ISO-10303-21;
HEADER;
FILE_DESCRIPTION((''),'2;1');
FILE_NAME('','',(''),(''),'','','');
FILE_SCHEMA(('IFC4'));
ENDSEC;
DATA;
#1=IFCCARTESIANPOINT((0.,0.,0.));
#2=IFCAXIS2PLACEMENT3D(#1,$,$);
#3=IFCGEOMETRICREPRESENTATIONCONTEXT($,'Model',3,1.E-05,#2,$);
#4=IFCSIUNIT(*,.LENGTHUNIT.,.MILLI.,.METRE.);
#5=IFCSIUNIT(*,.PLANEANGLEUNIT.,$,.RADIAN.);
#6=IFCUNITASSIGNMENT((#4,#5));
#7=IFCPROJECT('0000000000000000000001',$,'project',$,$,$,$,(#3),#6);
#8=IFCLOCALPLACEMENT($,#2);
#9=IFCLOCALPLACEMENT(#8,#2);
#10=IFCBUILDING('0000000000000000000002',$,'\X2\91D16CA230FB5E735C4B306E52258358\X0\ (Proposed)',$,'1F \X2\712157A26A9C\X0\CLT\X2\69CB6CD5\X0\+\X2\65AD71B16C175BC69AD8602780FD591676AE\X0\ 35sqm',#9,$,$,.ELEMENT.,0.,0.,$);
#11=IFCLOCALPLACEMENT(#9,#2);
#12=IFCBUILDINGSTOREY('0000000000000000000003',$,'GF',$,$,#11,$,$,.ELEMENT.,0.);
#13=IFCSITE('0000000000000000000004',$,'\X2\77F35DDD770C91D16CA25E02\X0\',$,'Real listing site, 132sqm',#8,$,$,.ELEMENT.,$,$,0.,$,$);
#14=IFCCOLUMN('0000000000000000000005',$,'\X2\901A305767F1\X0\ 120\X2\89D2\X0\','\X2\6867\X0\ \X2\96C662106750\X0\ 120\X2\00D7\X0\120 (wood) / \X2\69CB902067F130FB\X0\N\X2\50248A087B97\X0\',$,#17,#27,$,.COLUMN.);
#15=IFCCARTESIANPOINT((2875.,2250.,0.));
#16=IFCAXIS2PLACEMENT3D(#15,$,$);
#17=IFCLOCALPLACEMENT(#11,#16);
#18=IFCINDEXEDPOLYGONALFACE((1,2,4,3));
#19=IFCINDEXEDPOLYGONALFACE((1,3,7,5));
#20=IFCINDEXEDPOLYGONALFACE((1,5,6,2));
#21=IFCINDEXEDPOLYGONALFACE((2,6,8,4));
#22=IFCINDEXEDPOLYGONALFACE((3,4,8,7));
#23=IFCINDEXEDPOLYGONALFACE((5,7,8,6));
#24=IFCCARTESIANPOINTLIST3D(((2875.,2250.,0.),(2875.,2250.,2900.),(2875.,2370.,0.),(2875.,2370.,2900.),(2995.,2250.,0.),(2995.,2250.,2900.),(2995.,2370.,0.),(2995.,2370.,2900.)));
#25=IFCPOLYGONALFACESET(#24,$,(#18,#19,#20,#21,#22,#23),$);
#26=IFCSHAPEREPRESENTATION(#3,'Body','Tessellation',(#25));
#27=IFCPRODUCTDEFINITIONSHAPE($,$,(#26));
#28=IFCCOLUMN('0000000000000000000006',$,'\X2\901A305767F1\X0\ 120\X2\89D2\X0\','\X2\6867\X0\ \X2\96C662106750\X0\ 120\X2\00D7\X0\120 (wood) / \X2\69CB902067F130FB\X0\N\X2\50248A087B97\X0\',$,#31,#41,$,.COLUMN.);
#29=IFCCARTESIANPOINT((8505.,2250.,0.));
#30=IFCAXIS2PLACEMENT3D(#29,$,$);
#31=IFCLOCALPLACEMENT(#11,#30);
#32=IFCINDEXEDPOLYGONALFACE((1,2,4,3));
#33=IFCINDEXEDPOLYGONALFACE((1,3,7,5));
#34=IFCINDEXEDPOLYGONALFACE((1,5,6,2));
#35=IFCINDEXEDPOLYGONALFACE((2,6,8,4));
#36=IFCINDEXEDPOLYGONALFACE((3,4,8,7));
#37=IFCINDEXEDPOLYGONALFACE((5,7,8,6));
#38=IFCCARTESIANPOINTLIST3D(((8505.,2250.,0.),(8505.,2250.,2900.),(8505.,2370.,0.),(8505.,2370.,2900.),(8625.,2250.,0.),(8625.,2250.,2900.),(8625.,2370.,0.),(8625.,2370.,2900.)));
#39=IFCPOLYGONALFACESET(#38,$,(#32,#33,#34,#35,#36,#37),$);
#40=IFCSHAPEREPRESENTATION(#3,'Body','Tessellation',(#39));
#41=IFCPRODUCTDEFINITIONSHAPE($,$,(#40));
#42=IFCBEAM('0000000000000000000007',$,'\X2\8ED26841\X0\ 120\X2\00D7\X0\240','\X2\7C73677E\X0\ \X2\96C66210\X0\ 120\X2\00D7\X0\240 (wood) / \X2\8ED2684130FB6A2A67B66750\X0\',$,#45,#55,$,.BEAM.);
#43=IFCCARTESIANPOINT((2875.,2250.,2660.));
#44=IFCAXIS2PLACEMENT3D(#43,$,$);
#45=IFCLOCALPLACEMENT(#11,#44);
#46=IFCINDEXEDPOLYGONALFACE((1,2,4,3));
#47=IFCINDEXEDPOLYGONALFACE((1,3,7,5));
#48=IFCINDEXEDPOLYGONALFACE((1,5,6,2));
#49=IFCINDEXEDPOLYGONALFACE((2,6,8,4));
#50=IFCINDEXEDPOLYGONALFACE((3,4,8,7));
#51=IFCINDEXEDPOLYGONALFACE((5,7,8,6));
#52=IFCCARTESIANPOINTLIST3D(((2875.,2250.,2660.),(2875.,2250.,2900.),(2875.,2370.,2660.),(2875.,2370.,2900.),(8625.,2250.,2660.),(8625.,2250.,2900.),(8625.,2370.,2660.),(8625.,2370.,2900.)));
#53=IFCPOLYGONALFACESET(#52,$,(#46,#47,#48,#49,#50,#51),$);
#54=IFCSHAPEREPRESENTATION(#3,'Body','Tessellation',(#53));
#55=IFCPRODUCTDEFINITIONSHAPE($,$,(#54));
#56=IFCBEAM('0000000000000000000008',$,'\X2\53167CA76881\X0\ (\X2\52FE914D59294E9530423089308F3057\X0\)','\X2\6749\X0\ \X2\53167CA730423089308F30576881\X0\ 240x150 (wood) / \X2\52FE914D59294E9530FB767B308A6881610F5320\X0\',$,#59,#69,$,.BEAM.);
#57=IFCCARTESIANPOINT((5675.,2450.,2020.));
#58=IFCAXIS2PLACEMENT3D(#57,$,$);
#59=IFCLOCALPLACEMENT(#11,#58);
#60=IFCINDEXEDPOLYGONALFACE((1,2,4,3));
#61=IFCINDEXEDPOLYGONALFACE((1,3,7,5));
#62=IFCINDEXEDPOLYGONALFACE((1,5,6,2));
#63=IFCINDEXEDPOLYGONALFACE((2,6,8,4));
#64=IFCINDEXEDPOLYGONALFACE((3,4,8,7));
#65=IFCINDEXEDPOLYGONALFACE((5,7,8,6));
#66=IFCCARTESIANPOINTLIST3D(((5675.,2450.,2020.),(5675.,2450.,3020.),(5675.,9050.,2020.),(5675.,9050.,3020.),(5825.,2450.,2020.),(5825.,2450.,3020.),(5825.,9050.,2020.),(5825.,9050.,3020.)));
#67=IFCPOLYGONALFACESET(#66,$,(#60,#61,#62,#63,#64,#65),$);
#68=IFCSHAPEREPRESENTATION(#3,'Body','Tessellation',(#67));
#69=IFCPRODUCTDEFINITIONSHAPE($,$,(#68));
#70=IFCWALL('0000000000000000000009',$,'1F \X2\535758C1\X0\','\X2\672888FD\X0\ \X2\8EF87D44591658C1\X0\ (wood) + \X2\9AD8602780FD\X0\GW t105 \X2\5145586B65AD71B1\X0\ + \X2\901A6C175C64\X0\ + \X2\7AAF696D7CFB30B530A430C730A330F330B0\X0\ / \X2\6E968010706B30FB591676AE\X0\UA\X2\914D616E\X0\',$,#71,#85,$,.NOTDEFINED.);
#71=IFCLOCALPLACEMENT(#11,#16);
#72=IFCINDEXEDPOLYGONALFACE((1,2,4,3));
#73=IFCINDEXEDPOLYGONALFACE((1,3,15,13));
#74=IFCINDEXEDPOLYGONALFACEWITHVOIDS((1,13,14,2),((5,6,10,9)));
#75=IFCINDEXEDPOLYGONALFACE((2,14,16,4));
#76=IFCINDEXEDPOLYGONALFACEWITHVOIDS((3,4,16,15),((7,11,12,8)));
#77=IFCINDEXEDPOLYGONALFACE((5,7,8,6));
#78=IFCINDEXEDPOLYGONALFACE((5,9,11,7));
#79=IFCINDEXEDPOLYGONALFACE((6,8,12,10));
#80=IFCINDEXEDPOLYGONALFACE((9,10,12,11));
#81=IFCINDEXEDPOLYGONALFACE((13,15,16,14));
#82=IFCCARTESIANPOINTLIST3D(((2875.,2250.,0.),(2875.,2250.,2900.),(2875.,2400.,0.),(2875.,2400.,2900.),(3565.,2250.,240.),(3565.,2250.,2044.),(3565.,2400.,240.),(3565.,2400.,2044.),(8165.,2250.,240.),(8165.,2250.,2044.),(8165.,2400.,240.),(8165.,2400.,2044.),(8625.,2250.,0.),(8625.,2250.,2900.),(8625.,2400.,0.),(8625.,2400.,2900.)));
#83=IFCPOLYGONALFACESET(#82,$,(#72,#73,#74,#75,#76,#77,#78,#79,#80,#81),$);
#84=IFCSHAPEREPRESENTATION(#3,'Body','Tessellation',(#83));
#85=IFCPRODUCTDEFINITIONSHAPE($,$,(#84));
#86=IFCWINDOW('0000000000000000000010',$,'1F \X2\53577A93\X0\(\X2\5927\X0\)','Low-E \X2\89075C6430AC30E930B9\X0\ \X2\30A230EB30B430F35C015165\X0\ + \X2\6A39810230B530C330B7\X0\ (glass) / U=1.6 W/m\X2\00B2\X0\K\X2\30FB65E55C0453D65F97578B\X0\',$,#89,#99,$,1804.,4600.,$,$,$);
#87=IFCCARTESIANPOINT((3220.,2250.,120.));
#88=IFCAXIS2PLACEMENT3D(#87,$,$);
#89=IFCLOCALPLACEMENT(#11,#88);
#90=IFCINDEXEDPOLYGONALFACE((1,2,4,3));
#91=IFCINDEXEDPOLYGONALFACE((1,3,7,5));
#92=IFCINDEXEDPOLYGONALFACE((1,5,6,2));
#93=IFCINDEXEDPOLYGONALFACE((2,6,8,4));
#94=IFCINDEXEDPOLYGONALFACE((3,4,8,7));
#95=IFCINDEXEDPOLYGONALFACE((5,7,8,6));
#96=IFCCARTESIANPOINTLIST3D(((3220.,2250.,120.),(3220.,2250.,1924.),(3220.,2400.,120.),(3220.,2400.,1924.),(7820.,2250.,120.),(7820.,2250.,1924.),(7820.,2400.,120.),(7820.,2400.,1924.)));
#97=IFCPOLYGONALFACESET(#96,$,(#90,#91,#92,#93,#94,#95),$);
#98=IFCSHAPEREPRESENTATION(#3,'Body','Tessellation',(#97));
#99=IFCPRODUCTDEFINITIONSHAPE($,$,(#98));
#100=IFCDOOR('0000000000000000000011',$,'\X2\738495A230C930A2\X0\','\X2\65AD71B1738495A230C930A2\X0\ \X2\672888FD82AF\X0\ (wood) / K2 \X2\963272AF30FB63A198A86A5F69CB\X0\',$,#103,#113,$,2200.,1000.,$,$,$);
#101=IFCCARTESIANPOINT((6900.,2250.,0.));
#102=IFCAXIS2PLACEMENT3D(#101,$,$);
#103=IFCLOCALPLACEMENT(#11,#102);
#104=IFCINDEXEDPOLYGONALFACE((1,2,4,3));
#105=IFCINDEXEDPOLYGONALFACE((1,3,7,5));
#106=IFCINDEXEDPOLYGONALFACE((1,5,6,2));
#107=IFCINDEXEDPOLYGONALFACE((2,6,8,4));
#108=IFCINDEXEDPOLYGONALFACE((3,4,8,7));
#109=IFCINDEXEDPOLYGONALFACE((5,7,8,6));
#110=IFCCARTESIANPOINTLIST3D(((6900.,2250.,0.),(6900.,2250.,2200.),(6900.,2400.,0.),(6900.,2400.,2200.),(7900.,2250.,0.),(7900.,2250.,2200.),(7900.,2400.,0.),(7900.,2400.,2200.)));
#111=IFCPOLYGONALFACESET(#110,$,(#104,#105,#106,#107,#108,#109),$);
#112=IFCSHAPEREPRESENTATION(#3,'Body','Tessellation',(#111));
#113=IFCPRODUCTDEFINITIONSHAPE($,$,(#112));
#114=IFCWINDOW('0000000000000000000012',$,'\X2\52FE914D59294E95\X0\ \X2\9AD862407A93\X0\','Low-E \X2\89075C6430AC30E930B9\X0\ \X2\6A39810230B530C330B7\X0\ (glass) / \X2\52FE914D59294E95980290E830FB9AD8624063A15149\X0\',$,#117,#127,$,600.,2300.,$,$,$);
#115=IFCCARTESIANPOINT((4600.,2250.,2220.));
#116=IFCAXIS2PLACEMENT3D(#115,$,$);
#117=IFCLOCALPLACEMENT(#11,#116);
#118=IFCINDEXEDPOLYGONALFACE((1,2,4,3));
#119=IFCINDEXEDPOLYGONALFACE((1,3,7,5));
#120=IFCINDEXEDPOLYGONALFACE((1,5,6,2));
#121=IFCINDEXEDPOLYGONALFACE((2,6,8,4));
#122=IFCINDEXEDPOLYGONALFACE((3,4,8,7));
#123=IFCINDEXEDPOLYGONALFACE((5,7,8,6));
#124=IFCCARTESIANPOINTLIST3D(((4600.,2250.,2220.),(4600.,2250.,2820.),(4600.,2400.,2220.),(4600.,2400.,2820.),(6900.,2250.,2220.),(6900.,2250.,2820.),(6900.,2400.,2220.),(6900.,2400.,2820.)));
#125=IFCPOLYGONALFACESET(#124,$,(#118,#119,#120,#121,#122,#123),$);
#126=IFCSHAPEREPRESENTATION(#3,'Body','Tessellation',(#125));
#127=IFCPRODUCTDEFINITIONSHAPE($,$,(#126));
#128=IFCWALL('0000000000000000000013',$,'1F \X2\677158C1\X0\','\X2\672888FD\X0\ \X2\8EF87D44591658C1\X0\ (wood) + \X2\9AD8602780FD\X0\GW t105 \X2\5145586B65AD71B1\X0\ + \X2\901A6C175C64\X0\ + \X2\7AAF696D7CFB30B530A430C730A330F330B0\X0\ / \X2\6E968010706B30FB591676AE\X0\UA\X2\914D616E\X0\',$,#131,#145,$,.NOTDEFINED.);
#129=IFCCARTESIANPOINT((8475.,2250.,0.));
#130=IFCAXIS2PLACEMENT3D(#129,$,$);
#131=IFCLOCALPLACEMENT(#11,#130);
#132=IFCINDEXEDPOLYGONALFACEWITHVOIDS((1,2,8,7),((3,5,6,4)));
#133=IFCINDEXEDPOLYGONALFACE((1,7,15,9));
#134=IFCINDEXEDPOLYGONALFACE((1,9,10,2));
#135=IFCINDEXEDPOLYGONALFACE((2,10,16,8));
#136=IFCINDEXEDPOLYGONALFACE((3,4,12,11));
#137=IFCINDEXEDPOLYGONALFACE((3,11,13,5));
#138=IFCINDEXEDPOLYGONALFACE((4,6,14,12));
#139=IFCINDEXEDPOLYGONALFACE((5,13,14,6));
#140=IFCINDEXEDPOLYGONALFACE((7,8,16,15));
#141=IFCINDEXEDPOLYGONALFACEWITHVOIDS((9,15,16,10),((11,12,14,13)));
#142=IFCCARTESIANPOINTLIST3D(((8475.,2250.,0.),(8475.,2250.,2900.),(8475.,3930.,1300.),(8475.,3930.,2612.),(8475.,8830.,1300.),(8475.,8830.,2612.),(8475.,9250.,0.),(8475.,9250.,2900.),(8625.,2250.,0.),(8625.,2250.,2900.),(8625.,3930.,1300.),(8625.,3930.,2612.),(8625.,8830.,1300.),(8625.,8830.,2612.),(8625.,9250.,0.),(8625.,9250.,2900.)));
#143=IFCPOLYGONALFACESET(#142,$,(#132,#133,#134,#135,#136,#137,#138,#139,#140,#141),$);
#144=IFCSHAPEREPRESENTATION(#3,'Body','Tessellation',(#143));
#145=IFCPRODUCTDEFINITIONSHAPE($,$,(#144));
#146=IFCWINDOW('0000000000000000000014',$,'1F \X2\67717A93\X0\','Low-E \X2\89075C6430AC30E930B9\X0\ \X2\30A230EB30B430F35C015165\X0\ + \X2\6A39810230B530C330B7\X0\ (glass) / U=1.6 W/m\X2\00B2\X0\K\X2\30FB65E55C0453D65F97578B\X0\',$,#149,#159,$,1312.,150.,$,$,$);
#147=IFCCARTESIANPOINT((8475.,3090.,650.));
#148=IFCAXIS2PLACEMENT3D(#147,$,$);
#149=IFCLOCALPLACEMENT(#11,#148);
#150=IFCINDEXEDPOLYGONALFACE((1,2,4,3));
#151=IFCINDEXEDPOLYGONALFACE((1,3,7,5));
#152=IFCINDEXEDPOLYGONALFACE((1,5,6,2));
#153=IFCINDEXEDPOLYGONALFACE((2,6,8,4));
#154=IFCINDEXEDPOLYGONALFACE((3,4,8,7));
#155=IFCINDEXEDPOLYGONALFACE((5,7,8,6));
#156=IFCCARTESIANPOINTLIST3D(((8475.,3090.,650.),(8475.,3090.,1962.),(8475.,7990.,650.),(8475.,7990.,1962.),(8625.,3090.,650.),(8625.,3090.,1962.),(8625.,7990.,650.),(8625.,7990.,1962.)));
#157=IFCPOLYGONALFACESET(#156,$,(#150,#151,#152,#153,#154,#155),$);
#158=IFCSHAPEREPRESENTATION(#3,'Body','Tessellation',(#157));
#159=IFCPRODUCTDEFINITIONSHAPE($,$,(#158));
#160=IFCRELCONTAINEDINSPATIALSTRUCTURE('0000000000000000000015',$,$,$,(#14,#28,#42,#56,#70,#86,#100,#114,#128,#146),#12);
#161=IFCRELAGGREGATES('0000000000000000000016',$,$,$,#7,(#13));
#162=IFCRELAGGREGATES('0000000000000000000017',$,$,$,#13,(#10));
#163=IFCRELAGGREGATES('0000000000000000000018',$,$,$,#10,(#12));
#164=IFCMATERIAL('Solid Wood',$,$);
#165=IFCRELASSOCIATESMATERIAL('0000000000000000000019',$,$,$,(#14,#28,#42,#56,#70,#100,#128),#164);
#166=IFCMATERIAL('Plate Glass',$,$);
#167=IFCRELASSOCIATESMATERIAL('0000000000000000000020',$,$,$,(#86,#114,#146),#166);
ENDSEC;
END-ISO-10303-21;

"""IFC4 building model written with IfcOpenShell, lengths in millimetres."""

from ifc_helpers import new_model, si_unit, frame, frame_2d, origin, place, context, project, spatial, rectangle, extrude, material, element, fill, save


model = new_model("IFC4")

# Units and contexts
model_context = context("Model", 3, precision=1e-05, world=origin())
ifc_project = project(units=[si_unit("LENGTHUNIT", "METRE", prefix="MILLI"), si_unit("PLANEANGLEUNIT", "RADIAN")], contexts=[model_context])

# Site, building, storey
site_placement = place(None, origin())
site = spatial("IfcSite", under=ifc_project, at=site_placement, Name="石川県金沢市", ObjectType="Real listing site, 132sqm", CompositionType="ELEMENT", RefElevation=0.0)
building_placement = place(site_placement, origin())
building = spatial("IfcBuilding", under=site, at=building_placement, Name="金沢・平屋の別荘 (Proposed)", ObjectType="1F 無垢檜CLT構法+断熱気密高性能外皮 35sqm", CompositionType="ELEMENT", ElevationOfRefHeight=0.0, ElevationOfTerrain=0.0)
storey_placement = place(building_placement, origin())
storey = spatial("IfcBuildingStorey", under=building, at=storey_placement, Name="GF", CompositionType="ELEMENT", Elevation=0.0)

# Columns
ifc_material_1 = material(Name="Solid Wood")
column_1_placement = place(storey_placement, frame((2875.0, 2250.0, 0.0)))
element("IfcColumn", 1, at=column_1_placement, inside=storey, material=ifc_material_1, Name="通し柱 120角", Description="桧 集成材 120×120 (wood) / 構造柱・N値計算", PredefinedType="COLUMN", context=model_context, shape_type="SweptSolid", body=[
    extrude(rectangle(XDim=120.0, YDim=120.0, at=frame_2d((60.0, 60.0))), frame((2875.0, 2250.0, 0.0)), (0.0, 0.0, 1.0), 2900.0),
])
column_2_placement = place(storey_placement, frame((8505.0, 2250.0, 0.0)))
element("IfcColumn", 2, at=column_2_placement, inside=storey, material=ifc_material_1, Name="通し柱 120角", Description="桧 集成材 120×120 (wood) / 構造柱・N値計算", PredefinedType="COLUMN", context=model_context, shape_type="SweptSolid", body=[
    extrude(rectangle(XDim=120.0, YDim=120.0, at=frame_2d((60.0, 60.0))), frame((8505.0, 2250.0, 0.0)), (0.0, 0.0, 1.0), 2900.0),
])

# Beams
beam_1_placement = place(storey_placement, frame((2875.0, 2250.0, 2660.0)))
element("IfcBeam", 3, at=beam_1_placement, inside=storey, material=ifc_material_1, Name="軒桁 120×240", Description="米松 集成 120×240 (wood) / 軒桁・横架材", PredefinedType="BEAM", context=model_context, shape_type="SweptSolid", body=[
    extrude(rectangle(XDim=5750.0, YDim=120.0, at=frame_2d((2875.0, 60.0))), frame((2875.0, 2250.0, 2660.0)), (0.0, 0.0, 1.0), 240.0),
])
beam_2_placement = place(storey_placement, frame((5675.0, 2450.0, 2020.0)))
element("IfcBeam", 4, at=beam_2_placement, inside=storey, material=ifc_material_1, Name="化粧梁 (勾配天井あらわし)", Description="杉 化粧あらわし梁 240x150 (wood) / 勾配天井・登り梁意匠", PredefinedType="BEAM", context=model_context, shape_type="SweptSolid", body=[
    extrude(rectangle(XDim=150.0, YDim=6600.0, at=frame_2d((75.0, 3300.0))), frame((5675.0, 2450.0, 2020.0)), (0.0, 0.0, 1.0), 1000.0),
])

# Wall, openings, windows, door
wall_1_placement = place(storey_placement, frame((2875.0, 2250.0, 0.0)))
wall_1 = element("IfcWall", 5, at=wall_1_placement, inside=storey, material=ifc_material_1, Name="1F 南壁", Description="木製 軸組外壁 (wood) + 高性能GW t105 充填断熱 + 通気層 + 窯業系サイディング / 準耐火・外皮UA配慮", PredefinedType="NOTDEFINED", context=model_context, shape_type="SweptSolid", body=[
    extrude(rectangle(XDim=5750.0, YDim=150.0, at=frame_2d((2875.0, 75.0))), frame((2875.0, 2250.0, 0.0)), (0.0, 0.0, 1.0), 2900.0),
])
opening_1_placement = place(storey_placement, frame((3220.0, 2250.0, 120.0)))
opening_1 = element("IfcOpeningElement", 6, at=opening_1_placement, cuts=wall_1, PredefinedType="NOTDEFINED", context=model_context, shape_type="SweptSolid", body=[
    extrude(rectangle(XDim=4600.0, YDim=150.0, at=frame_2d((2300.0, 75.0))), frame((3220.0, 2250.0, 120.0)), (0.0, 0.0, 1.0), 1804.0),
])
opening_2_placement = place(storey_placement, frame((6900.0, 2250.0, 0.0)))
opening_2 = element("IfcOpeningElement", 7, at=opening_2_placement, cuts=wall_1, PredefinedType="NOTDEFINED", context=model_context, shape_type="SweptSolid", body=[
    extrude(rectangle(XDim=1000.0, YDim=150.0, at=frame_2d((500.0, 75.0))), frame((6900.0, 2250.0, 0.0)), (0.0, 0.0, 1.0), 2200.0),
])
opening_3_placement = place(storey_placement, frame((4600.0, 2250.0, 2220.0)))
opening_3 = element("IfcOpeningElement", 8, at=opening_3_placement, cuts=wall_1, PredefinedType="NOTDEFINED", context=model_context, shape_type="SweptSolid", body=[
    extrude(rectangle(XDim=2300.0, YDim=150.0, at=frame_2d((1150.0, 75.0))), frame((4600.0, 2250.0, 2220.0)), (0.0, 0.0, 1.0), 600.0),
])
ifc_material_2 = material(Name="Plate Glass")
window_1_placement = place(storey_placement, frame((3220.0, 2250.0, 120.0)))
window_1 = element("IfcWindow", 9, at=window_1_placement, inside=storey, material=ifc_material_2, Name="1F 南窓(大)", Description="Low-E 複層ガラス アルゴン封入 + 樹脂サッシ (glass) / U=1.6 W/m²K・日射取得型", OverallHeight=1804.0, OverallWidth=4600.0, context=model_context, shape_type="SweptSolid", body=[
    extrude(rectangle(XDim=4600.0, YDim=150.0, at=frame_2d((2300.0, 75.0))), frame((3220.0, 2250.0, 120.0)), (0.0, 0.0, 1.0), 1804.0),
])
fill(opening_1, window_1)
door_placement = place(storey_placement, frame((6900.0, 2250.0, 0.0)))
door = element("IfcDoor", 10, at=door_placement, inside=storey, material=ifc_material_1, Name="玄関ドア", Description="断熱玄関ドア 木製芯 (wood) / K2 防犯・採風機構", OverallHeight=2200.0, OverallWidth=1000.0, context=model_context, shape_type="SweptSolid", body=[
    extrude(rectangle(XDim=1000.0, YDim=150.0, at=frame_2d((500.0, 75.0))), frame((6900.0, 2250.0, 0.0)), (0.0, 0.0, 1.0), 2200.0),
])
fill(opening_2, door)
window_2_placement = place(storey_placement, frame((4600.0, 2250.0, 2220.0)))
window_2 = element("IfcWindow", 11, at=window_2_placement, inside=storey, material=ifc_material_2, Name="勾配天井 高所窓", Description="Low-E 複層ガラス 樹脂サッシ (glass) / 勾配天井頂部・高所採光", OverallHeight=600.0, OverallWidth=2300.0, context=model_context, shape_type="SweptSolid", body=[
    extrude(rectangle(XDim=2300.0, YDim=150.0, at=frame_2d((1150.0, 75.0))), frame((4600.0, 2250.0, 2220.0)), (0.0, 0.0, 1.0), 600.0),
])
fill(opening_3, window_2)

# Wall, opening, window
wall_2_placement = place(storey_placement, frame((8475.0, 2250.0, 0.0)))
wall_2 = element("IfcWall", 12, at=wall_2_placement, inside=storey, material=ifc_material_1, Name="1F 東壁", Description="木製 軸組外壁 (wood) + 高性能GW t105 充填断熱 + 通気層 + 窯業系サイディング / 準耐火・外皮UA配慮", PredefinedType="NOTDEFINED", context=model_context, shape_type="SweptSolid", body=[
    extrude(rectangle(XDim=150.0, YDim=7000.0, at=frame_2d((75.0, 3500.0))), frame((8475.0, 2250.0, 0.0)), (0.0, 0.0, 1.0), 2900.0),
])
opening_4_placement = place(storey_placement, frame((8475.0, 3090.0, 650.0)))
opening_4 = element("IfcOpeningElement", 13, at=opening_4_placement, cuts=wall_2, PredefinedType="NOTDEFINED", context=model_context, shape_type="SweptSolid", body=[
    extrude(rectangle(XDim=150.0, YDim=4900.0, at=frame_2d((75.0, 2450.0))), frame((8475.0, 3090.0, 650.0)), (0.0, 0.0, 1.0), 1312.0),
])
window_3_placement = place(storey_placement, frame((8475.0, 3090.0, 650.0)))
window_3 = element("IfcWindow", 14, at=window_3_placement, inside=storey, material=ifc_material_2, Name="1F 東窓", Description="Low-E 複層ガラス アルゴン封入 + 樹脂サッシ (glass) / U=1.6 W/m²K・日射取得型", OverallHeight=1312.0, OverallWidth=150.0, context=model_context, shape_type="SweptSolid", body=[
    extrude(rectangle(XDim=150.0, YDim=4900.0, at=frame_2d((75.0, 2450.0))), frame((8475.0, 3090.0, 650.0)), (0.0, 0.0, 1.0), 1312.0),
])
fill(opening_4, window_3)

save(model, "model.ifc")
